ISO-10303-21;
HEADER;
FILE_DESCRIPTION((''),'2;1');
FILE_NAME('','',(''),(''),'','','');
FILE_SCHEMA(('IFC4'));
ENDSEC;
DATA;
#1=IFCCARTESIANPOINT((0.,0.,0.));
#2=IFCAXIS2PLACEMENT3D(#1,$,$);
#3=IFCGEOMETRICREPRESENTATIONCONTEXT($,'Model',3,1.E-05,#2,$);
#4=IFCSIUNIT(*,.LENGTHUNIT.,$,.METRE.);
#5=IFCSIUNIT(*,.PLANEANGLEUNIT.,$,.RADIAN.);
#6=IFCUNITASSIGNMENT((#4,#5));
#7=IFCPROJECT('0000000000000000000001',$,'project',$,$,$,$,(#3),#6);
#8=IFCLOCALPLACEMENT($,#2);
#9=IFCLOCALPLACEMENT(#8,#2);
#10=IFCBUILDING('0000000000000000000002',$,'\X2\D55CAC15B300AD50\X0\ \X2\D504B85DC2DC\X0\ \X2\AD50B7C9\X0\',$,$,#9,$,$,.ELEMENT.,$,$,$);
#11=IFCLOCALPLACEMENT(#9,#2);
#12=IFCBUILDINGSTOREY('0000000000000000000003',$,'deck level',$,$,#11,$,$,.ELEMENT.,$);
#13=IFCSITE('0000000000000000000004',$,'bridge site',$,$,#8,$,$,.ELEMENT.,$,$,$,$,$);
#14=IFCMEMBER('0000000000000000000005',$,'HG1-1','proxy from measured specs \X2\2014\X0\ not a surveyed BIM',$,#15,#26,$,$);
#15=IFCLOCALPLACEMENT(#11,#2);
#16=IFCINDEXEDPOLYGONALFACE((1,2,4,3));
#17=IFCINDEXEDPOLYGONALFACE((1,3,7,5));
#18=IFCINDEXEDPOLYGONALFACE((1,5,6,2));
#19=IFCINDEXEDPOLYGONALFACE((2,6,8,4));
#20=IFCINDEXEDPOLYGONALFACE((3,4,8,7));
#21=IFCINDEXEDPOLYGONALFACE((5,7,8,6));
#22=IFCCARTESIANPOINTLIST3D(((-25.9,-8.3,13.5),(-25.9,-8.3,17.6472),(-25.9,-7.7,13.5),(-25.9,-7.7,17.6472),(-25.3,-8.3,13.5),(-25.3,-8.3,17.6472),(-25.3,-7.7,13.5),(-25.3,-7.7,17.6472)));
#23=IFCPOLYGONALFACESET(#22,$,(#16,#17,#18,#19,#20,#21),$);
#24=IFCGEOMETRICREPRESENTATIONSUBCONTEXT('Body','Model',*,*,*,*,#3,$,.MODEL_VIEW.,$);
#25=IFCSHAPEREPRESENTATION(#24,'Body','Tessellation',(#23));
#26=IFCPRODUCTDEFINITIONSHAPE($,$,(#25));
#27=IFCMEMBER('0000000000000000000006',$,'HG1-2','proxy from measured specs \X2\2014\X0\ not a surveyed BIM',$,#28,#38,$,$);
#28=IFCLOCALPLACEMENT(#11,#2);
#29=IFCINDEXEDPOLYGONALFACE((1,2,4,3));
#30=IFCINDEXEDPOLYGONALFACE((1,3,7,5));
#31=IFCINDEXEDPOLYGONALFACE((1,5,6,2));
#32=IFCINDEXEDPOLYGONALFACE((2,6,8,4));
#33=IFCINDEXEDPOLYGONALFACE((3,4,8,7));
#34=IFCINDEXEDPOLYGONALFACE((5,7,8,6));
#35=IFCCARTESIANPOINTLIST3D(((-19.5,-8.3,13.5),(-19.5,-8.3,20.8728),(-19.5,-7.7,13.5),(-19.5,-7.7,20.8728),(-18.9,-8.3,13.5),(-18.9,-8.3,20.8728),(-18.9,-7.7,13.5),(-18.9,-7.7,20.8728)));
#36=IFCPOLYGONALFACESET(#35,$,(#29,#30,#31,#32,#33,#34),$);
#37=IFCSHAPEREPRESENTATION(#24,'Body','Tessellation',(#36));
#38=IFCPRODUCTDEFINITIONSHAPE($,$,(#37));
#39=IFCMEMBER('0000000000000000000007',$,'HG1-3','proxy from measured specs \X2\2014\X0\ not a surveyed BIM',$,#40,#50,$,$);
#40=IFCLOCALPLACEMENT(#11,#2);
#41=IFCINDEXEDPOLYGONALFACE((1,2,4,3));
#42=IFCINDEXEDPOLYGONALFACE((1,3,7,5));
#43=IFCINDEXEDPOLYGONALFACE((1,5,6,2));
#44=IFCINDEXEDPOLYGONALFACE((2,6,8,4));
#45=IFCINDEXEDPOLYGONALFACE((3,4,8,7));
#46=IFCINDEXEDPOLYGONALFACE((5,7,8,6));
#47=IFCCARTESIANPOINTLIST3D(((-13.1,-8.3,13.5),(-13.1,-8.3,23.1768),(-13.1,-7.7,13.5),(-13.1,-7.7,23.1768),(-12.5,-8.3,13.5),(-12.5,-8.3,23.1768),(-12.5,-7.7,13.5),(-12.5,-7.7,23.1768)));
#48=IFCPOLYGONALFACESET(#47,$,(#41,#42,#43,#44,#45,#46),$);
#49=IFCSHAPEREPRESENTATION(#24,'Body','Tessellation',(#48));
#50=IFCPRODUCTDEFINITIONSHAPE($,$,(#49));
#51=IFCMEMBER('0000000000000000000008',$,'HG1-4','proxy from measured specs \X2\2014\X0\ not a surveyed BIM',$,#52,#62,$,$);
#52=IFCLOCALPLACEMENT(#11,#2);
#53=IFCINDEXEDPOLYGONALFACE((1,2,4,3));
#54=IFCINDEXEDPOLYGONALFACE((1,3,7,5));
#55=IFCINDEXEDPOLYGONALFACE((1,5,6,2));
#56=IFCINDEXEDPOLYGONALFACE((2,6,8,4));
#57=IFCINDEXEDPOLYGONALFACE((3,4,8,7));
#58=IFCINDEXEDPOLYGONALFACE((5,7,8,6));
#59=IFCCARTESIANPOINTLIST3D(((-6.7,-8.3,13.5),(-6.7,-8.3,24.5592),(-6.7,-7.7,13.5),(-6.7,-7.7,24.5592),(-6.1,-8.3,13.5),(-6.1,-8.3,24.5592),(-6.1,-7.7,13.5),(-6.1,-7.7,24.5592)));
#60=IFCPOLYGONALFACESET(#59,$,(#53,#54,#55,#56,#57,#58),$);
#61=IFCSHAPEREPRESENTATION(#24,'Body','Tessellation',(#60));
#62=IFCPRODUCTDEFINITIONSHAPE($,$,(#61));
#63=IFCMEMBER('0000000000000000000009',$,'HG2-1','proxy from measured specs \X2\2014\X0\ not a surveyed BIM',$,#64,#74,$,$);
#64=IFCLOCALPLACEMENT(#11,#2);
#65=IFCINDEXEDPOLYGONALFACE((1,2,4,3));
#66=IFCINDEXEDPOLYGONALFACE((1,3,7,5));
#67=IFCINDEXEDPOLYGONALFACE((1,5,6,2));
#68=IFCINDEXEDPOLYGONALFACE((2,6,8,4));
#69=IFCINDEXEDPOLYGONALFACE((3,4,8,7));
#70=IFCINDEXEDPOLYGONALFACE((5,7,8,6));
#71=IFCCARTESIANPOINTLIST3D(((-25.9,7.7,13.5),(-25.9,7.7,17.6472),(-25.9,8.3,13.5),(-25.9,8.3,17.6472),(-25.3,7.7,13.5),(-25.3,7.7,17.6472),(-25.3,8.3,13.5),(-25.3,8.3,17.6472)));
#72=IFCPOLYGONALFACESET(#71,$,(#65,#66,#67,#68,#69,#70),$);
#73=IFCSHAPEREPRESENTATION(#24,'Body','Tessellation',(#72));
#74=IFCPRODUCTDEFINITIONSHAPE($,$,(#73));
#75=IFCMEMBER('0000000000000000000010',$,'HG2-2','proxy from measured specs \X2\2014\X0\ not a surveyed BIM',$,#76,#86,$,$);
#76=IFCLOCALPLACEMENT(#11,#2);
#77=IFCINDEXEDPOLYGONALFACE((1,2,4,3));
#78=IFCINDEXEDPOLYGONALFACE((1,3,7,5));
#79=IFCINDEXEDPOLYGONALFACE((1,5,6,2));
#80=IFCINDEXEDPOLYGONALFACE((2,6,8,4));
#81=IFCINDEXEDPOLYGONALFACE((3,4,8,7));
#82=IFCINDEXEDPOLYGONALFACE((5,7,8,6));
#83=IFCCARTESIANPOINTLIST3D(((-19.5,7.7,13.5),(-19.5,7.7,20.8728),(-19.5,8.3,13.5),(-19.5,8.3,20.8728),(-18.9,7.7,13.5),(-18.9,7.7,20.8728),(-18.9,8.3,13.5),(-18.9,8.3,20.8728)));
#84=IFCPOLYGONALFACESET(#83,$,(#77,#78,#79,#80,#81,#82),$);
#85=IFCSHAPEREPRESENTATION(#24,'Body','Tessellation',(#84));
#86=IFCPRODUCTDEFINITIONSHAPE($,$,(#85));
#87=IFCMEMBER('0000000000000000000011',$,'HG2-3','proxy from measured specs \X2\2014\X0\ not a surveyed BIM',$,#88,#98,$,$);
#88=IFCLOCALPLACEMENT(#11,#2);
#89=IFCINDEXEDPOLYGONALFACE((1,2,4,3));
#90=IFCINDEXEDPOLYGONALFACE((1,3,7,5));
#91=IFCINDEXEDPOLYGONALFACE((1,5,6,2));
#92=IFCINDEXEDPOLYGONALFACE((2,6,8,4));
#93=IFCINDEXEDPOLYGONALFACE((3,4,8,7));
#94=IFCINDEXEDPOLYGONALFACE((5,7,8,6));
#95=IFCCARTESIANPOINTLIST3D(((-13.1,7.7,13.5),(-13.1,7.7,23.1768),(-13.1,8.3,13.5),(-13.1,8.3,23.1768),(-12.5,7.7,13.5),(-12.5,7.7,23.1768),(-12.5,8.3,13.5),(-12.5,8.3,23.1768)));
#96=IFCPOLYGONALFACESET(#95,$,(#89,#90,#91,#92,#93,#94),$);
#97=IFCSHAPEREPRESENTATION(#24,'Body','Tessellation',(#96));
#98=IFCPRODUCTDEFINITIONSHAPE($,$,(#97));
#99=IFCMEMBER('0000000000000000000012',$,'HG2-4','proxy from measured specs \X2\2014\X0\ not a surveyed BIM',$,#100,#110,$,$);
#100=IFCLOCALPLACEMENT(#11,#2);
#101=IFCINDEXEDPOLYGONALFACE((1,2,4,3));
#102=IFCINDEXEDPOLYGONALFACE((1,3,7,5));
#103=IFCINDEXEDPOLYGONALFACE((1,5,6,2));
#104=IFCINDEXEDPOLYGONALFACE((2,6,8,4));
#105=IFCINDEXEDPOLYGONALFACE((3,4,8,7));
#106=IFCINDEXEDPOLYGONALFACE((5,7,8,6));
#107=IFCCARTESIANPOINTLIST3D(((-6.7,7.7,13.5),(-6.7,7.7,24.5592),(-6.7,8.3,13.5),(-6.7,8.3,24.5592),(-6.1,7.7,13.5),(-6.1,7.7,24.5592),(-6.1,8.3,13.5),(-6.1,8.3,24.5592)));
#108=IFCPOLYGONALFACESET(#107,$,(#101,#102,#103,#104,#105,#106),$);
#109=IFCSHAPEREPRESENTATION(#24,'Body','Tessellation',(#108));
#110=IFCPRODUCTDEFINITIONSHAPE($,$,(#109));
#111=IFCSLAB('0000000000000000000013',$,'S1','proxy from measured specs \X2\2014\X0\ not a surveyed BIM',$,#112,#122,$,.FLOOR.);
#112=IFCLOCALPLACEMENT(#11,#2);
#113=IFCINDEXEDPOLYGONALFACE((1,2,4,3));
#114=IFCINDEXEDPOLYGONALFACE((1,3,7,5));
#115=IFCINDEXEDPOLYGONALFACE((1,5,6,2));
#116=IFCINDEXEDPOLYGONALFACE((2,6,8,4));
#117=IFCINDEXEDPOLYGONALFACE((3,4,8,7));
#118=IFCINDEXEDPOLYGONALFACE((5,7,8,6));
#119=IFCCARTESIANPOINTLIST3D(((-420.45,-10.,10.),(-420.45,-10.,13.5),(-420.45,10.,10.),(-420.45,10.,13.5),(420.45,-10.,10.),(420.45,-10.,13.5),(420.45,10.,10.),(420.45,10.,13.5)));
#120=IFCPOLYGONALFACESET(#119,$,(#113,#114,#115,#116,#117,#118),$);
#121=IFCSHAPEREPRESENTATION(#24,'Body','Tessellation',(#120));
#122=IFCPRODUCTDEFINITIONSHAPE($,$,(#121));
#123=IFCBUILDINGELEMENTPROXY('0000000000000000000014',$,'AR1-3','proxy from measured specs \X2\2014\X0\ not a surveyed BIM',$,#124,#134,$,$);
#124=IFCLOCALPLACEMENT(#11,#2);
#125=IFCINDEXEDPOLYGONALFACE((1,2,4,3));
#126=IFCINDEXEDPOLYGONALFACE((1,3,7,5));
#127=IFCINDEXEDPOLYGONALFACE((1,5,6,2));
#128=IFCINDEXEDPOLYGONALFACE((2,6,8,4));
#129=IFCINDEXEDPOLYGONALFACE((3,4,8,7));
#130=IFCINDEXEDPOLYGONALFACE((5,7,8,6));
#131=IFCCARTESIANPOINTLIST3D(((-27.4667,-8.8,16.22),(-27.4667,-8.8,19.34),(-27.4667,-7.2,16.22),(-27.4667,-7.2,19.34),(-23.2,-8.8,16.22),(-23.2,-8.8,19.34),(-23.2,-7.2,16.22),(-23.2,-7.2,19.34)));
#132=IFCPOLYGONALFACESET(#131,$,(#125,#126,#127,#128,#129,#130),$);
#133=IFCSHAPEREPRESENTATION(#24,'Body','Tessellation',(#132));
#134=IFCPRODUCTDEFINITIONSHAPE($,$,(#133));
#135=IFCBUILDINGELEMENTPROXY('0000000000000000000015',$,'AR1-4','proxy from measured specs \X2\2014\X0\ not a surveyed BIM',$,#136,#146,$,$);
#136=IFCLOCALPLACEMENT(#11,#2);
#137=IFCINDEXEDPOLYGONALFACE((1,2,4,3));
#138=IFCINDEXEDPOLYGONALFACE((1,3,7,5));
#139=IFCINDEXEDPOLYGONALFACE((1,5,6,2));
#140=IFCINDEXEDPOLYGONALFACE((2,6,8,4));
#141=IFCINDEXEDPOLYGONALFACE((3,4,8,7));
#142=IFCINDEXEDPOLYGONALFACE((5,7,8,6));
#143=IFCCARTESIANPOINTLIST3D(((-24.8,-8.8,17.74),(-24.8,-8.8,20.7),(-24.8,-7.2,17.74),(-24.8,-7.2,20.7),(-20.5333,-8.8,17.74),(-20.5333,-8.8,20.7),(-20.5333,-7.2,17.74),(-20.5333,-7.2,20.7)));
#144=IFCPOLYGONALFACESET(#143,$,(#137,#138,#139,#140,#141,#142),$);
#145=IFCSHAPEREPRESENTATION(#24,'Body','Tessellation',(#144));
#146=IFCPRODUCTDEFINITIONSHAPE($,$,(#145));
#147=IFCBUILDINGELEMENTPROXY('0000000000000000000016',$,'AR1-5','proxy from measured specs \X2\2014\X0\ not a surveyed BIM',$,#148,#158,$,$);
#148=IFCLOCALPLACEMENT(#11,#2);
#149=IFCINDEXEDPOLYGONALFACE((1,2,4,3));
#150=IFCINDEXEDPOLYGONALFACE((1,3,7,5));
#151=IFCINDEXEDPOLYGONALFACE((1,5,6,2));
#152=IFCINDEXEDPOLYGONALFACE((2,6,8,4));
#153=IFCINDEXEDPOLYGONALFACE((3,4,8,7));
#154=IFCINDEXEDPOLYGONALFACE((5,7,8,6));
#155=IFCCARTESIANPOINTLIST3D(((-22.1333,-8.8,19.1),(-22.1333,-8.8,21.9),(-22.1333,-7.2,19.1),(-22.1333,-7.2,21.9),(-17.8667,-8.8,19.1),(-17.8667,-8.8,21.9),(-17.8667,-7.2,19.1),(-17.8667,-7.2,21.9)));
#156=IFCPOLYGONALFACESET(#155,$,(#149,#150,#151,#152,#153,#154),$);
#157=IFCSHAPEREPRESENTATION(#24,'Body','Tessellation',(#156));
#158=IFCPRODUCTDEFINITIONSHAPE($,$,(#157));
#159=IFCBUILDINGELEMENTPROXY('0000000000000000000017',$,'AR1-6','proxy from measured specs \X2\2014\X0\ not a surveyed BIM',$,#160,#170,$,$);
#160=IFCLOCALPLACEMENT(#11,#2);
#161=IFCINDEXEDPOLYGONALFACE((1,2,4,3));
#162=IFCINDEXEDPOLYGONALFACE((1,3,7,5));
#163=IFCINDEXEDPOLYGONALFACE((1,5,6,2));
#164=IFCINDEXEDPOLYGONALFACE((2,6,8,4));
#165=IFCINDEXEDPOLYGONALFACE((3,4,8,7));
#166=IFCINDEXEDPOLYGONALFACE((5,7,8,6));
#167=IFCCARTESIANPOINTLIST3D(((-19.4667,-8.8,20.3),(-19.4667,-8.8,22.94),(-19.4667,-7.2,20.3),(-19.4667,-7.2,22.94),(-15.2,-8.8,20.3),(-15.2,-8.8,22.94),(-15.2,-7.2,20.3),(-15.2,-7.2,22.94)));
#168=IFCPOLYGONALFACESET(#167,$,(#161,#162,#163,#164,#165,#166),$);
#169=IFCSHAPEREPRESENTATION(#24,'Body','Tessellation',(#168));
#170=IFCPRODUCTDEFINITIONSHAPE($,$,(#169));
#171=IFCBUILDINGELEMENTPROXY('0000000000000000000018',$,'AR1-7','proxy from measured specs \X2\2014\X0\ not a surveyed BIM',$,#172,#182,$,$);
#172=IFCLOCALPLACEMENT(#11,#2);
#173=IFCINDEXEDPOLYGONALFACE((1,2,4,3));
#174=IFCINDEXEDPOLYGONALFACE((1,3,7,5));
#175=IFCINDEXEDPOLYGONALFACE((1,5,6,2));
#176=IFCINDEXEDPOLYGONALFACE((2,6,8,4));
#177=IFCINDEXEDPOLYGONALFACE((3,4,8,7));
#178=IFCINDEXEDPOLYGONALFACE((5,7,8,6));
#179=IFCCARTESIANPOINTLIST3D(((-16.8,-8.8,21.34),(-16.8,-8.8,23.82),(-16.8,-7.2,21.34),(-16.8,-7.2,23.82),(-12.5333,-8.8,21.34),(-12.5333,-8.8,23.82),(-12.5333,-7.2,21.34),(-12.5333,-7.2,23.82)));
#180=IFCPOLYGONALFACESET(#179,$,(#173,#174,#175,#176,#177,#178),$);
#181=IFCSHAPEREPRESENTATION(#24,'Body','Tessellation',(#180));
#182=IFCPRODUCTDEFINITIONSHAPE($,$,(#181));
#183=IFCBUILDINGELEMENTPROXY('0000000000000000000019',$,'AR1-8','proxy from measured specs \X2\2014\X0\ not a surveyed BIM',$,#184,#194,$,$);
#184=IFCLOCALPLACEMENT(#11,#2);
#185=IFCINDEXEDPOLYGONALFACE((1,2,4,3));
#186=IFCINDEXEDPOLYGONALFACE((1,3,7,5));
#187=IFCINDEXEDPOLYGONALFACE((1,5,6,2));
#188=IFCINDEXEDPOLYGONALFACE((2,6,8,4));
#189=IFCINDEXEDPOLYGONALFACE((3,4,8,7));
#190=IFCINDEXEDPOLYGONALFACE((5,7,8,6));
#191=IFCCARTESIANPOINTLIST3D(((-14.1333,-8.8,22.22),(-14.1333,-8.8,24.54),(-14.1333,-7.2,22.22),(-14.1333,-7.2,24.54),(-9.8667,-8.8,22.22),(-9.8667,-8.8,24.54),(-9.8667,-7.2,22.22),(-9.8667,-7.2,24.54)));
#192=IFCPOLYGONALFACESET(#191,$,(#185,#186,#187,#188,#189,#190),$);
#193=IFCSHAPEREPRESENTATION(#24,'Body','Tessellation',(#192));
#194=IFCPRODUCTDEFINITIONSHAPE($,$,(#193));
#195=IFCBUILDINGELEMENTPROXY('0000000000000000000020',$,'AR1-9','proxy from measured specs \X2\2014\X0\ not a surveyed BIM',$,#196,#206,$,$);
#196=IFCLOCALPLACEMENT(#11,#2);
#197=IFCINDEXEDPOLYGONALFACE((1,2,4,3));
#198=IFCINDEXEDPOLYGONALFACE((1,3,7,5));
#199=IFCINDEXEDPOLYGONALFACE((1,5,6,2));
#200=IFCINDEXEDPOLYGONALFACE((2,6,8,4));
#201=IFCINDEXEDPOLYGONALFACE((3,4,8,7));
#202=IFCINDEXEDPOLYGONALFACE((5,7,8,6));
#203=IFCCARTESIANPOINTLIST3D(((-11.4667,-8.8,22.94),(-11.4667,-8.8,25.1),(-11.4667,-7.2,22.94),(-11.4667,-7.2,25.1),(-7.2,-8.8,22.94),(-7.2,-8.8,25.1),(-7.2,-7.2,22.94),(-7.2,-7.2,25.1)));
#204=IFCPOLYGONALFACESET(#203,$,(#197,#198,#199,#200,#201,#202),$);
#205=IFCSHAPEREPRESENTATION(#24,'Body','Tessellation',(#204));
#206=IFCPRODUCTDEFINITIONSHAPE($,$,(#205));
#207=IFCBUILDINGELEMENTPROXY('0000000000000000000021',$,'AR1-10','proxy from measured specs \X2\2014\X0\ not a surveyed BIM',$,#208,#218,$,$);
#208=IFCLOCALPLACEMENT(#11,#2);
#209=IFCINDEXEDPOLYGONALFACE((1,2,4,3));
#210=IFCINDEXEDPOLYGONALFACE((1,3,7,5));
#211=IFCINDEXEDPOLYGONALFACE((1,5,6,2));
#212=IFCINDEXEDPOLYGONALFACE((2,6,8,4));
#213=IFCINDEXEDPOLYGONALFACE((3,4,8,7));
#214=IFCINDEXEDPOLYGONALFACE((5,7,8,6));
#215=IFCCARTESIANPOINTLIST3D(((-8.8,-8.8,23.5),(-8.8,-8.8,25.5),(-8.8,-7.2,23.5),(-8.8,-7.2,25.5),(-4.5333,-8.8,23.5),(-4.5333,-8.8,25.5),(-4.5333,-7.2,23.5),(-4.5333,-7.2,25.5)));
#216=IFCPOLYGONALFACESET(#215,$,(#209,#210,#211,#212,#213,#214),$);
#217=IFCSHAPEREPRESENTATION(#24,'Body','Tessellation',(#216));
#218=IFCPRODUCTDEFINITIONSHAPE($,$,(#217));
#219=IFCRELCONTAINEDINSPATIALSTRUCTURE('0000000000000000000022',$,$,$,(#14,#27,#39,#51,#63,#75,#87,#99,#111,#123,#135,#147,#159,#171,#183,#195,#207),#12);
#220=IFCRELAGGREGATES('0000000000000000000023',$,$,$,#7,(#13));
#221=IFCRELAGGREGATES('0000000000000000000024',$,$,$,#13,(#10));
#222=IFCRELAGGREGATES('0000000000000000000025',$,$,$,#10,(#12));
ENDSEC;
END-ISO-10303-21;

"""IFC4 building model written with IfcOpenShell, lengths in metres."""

from ifc_helpers import new_model, si_unit, frame, origin, origin_2d, place, context, subcontext, project, spatial, rectangle, extrude, element, save


model = new_model("IFC4")

# Units and contexts
model_context = context("Model", 3, precision=1e-05, world=origin())
body_context = subcontext(model_context, "Body", "Model", "MODEL_VIEW")
ifc_project = project(units=[si_unit("LENGTHUNIT", "METRE"), si_unit("PLANEANGLEUNIT", "RADIAN")], contexts=[model_context])

# Site, building, storey
site_placement = place(None, origin())
site = spatial("IfcSite", under=ifc_project, at=site_placement, Name="bridge site", CompositionType="ELEMENT")
building_placement = place(site_placement, origin())
building = spatial("IfcBuilding", under=site, at=building_placement, Name="한강대교 프록시 교량", CompositionType="ELEMENT")
storey_placement = place(building_placement, origin())
storey = spatial("IfcBuildingStorey", under=building, at=storey_placement, Name="deck level", CompositionType="ELEMENT")

# Members
member_1_placement = place(storey_placement, frame((-25.6, -8.0, 13.5)))
element("IfcMember", 1, at=member_1_placement, inside=storey, Name="HG1-1", Description="proxy from measured specs — not a surveyed BIM", context=body_context, shape_type="SweptSolid", body=[
    extrude(rectangle(XDim=0.6, YDim=0.6, at=origin_2d()), origin(), (0.0, 0.0, 1.0), 4.1472),
])
member_2_placement = place(storey_placement, frame((-19.2, -8.0, 13.5)))
element("IfcMember", 2, at=member_2_placement, inside=storey, Name="HG1-2", Description="proxy from measured specs — not a surveyed BIM", context=body_context, shape_type="SweptSolid", body=[
    extrude(rectangle(XDim=0.6, YDim=0.6, at=origin_2d()), origin(), (0.0, 0.0, 1.0), 7.3728),
])
member_3_placement = place(storey_placement, frame((-12.8, -8.0, 13.5)))
element("IfcMember", 3, at=member_3_placement, inside=storey, Name="HG1-3", Description="proxy from measured specs — not a surveyed BIM", context=body_context, shape_type="SweptSolid", body=[
    extrude(rectangle(XDim=0.6, YDim=0.6, at=origin_2d()), origin(), (0.0, 0.0, 1.0), 9.6768),
])
member_4_placement = place(storey_placement, frame((-6.4, -8.0, 13.5)))
element("IfcMember", 4, at=member_4_placement, inside=storey, Name="HG1-4", Description="proxy from measured specs — not a surveyed BIM", context=body_context, shape_type="SweptSolid", body=[
    extrude(rectangle(XDim=0.6, YDim=0.6, at=origin_2d()), origin(), (0.0, 0.0, 1.0), 11.0592),
])
member_5_placement = place(storey_placement, frame((-25.6, 8.0, 13.5)))
element("IfcMember", 5, at=member_5_placement, inside=storey, Name="HG2-1", Description="proxy from measured specs — not a surveyed BIM", context=body_context, shape_type="SweptSolid", body=[
    extrude(rectangle(XDim=0.6, YDim=0.6, at=origin_2d()), origin(), (0.0, 0.0, 1.0), 4.1472),
])
member_6_placement = place(storey_placement, frame((-19.2, 8.0, 13.5)))
element("IfcMember", 6, at=member_6_placement, inside=storey, Name="HG2-2", Description="proxy from measured specs — not a surveyed BIM", context=body_context, shape_type="SweptSolid", body=[
    extrude(rectangle(XDim=0.6, YDim=0.6, at=origin_2d()), origin(), (0.0, 0.0, 1.0), 7.3728),
])
member_7_placement = place(storey_placement, frame((-12.8, 8.0, 13.5)))
element("IfcMember", 7, at=member_7_placement, inside=storey, Name="HG2-3", Description="proxy from measured specs — not a surveyed BIM", context=body_context, shape_type="SweptSolid", body=[
    extrude(rectangle(XDim=0.6, YDim=0.6, at=origin_2d()), origin(), (0.0, 0.0, 1.0), 9.6768),
])
member_8_placement = place(storey_placement, frame((-6.4, 8.0, 13.5)))
element("IfcMember", 8, at=member_8_placement, inside=storey, Name="HG2-4", Description="proxy from measured specs — not a surveyed BIM", context=body_context, shape_type="SweptSolid", body=[
    extrude(rectangle(XDim=0.6, YDim=0.6, at=origin_2d()), origin(), (0.0, 0.0, 1.0), 11.0592),
])

# Slab
slab_placement = place(storey_placement, frame((0.0, 0.0, 10.0)))
element("IfcSlab", 9, at=slab_placement, inside=storey, Name="S1", Description="proxy from measured specs — not a surveyed BIM", PredefinedType="FLOOR", context=body_context, shape_type="SweptSolid", body=[
    extrude(rectangle(XDim=840.9, YDim=20.0, at=origin_2d()), origin(), (0.0, 0.0, 1.0), 3.5),
])

# Building element proxies
proxy_1_placement = place(storey_placement, frame((-25.3333, -8.0, 16.22)))
element("IfcBuildingElementProxy", 10, at=proxy_1_placement, inside=storey, Name="AR1-3", Description="proxy from measured specs — not a surveyed BIM", context=body_context, shape_type="SweptSolid", body=[
    extrude(rectangle(XDim=4.2667, YDim=1.6, at=origin_2d()), origin(), (0.0, 0.0, 1.0), 3.12),
])
proxy_2_placement = place(storey_placement, frame((-22.6667, -8.0, 17.74)))
element("IfcBuildingElementProxy", 11, at=proxy_2_placement, inside=storey, Name="AR1-4", Description="proxy from measured specs — not a surveyed BIM", context=body_context, shape_type="SweptSolid", body=[
    extrude(rectangle(XDim=4.2667, YDim=1.6, at=origin_2d()), origin(), (0.0, 0.0, 1.0), 2.96),
])
proxy_3_placement = place(storey_placement, frame((-20.0, -8.0, 19.1)))
element("IfcBuildingElementProxy", 12, at=proxy_3_placement, inside=storey, Name="AR1-5", Description="proxy from measured specs — not a surveyed BIM", context=body_context, shape_type="SweptSolid", body=[
    extrude(rectangle(XDim=4.2667, YDim=1.6, at=origin_2d()), origin(), (0.0, 0.0, 1.0), 2.8),
])
proxy_4_placement = place(storey_placement, frame((-17.3333, -8.0, 20.3)))
element("IfcBuildingElementProxy", 13, at=proxy_4_placement, inside=storey, Name="AR1-6", Description="proxy from measured specs — not a surveyed BIM", context=body_context, shape_type="SweptSolid", body=[
    extrude(rectangle(XDim=4.2667, YDim=1.6, at=origin_2d()), origin(), (0.0, 0.0, 1.0), 2.64),
])
proxy_5_placement = place(storey_placement, frame((-14.6667, -8.0, 21.34)))
element("IfcBuildingElementProxy", 14, at=proxy_5_placement, inside=storey, Name="AR1-7", Description="proxy from measured specs — not a surveyed BIM", context=body_context, shape_type="SweptSolid", body=[
    extrude(rectangle(XDim=4.2667, YDim=1.6, at=origin_2d()), origin(), (0.0, 0.0, 1.0), 2.48),
])
proxy_6_placement = place(storey_placement, frame((-12.0, -8.0, 22.22)))
element("IfcBuildingElementProxy", 15, at=proxy_6_placement, inside=storey, Name="AR1-8", Description="proxy from measured specs — not a surveyed BIM", context=body_context, shape_type="SweptSolid", body=[
    extrude(rectangle(XDim=4.2667, YDim=1.6, at=origin_2d()), origin(), (0.0, 0.0, 1.0), 2.32),
])
proxy_7_placement = place(storey_placement, frame((-9.3333, -8.0, 22.94)))
element("IfcBuildingElementProxy", 16, at=proxy_7_placement, inside=storey, Name="AR1-9", Description="proxy from measured specs — not a surveyed BIM", context=body_context, shape_type="SweptSolid", body=[
    extrude(rectangle(XDim=4.2667, YDim=1.6, at=origin_2d()), origin(), (0.0, 0.0, 1.0), 2.16),
])
proxy_8_placement = place(storey_placement, frame((-6.6667, -8.0, 23.5)))
element("IfcBuildingElementProxy", 17, at=proxy_8_placement, inside=storey, Name="AR1-10", Description="proxy from measured specs — not a surveyed BIM", context=body_context, shape_type="SweptSolid", body=[
    extrude(rectangle(XDim=4.2667, YDim=1.6, at=origin_2d()), origin(), (0.0, 0.0, 1.0), 2.0),
])

save(model, "model.ifc")
